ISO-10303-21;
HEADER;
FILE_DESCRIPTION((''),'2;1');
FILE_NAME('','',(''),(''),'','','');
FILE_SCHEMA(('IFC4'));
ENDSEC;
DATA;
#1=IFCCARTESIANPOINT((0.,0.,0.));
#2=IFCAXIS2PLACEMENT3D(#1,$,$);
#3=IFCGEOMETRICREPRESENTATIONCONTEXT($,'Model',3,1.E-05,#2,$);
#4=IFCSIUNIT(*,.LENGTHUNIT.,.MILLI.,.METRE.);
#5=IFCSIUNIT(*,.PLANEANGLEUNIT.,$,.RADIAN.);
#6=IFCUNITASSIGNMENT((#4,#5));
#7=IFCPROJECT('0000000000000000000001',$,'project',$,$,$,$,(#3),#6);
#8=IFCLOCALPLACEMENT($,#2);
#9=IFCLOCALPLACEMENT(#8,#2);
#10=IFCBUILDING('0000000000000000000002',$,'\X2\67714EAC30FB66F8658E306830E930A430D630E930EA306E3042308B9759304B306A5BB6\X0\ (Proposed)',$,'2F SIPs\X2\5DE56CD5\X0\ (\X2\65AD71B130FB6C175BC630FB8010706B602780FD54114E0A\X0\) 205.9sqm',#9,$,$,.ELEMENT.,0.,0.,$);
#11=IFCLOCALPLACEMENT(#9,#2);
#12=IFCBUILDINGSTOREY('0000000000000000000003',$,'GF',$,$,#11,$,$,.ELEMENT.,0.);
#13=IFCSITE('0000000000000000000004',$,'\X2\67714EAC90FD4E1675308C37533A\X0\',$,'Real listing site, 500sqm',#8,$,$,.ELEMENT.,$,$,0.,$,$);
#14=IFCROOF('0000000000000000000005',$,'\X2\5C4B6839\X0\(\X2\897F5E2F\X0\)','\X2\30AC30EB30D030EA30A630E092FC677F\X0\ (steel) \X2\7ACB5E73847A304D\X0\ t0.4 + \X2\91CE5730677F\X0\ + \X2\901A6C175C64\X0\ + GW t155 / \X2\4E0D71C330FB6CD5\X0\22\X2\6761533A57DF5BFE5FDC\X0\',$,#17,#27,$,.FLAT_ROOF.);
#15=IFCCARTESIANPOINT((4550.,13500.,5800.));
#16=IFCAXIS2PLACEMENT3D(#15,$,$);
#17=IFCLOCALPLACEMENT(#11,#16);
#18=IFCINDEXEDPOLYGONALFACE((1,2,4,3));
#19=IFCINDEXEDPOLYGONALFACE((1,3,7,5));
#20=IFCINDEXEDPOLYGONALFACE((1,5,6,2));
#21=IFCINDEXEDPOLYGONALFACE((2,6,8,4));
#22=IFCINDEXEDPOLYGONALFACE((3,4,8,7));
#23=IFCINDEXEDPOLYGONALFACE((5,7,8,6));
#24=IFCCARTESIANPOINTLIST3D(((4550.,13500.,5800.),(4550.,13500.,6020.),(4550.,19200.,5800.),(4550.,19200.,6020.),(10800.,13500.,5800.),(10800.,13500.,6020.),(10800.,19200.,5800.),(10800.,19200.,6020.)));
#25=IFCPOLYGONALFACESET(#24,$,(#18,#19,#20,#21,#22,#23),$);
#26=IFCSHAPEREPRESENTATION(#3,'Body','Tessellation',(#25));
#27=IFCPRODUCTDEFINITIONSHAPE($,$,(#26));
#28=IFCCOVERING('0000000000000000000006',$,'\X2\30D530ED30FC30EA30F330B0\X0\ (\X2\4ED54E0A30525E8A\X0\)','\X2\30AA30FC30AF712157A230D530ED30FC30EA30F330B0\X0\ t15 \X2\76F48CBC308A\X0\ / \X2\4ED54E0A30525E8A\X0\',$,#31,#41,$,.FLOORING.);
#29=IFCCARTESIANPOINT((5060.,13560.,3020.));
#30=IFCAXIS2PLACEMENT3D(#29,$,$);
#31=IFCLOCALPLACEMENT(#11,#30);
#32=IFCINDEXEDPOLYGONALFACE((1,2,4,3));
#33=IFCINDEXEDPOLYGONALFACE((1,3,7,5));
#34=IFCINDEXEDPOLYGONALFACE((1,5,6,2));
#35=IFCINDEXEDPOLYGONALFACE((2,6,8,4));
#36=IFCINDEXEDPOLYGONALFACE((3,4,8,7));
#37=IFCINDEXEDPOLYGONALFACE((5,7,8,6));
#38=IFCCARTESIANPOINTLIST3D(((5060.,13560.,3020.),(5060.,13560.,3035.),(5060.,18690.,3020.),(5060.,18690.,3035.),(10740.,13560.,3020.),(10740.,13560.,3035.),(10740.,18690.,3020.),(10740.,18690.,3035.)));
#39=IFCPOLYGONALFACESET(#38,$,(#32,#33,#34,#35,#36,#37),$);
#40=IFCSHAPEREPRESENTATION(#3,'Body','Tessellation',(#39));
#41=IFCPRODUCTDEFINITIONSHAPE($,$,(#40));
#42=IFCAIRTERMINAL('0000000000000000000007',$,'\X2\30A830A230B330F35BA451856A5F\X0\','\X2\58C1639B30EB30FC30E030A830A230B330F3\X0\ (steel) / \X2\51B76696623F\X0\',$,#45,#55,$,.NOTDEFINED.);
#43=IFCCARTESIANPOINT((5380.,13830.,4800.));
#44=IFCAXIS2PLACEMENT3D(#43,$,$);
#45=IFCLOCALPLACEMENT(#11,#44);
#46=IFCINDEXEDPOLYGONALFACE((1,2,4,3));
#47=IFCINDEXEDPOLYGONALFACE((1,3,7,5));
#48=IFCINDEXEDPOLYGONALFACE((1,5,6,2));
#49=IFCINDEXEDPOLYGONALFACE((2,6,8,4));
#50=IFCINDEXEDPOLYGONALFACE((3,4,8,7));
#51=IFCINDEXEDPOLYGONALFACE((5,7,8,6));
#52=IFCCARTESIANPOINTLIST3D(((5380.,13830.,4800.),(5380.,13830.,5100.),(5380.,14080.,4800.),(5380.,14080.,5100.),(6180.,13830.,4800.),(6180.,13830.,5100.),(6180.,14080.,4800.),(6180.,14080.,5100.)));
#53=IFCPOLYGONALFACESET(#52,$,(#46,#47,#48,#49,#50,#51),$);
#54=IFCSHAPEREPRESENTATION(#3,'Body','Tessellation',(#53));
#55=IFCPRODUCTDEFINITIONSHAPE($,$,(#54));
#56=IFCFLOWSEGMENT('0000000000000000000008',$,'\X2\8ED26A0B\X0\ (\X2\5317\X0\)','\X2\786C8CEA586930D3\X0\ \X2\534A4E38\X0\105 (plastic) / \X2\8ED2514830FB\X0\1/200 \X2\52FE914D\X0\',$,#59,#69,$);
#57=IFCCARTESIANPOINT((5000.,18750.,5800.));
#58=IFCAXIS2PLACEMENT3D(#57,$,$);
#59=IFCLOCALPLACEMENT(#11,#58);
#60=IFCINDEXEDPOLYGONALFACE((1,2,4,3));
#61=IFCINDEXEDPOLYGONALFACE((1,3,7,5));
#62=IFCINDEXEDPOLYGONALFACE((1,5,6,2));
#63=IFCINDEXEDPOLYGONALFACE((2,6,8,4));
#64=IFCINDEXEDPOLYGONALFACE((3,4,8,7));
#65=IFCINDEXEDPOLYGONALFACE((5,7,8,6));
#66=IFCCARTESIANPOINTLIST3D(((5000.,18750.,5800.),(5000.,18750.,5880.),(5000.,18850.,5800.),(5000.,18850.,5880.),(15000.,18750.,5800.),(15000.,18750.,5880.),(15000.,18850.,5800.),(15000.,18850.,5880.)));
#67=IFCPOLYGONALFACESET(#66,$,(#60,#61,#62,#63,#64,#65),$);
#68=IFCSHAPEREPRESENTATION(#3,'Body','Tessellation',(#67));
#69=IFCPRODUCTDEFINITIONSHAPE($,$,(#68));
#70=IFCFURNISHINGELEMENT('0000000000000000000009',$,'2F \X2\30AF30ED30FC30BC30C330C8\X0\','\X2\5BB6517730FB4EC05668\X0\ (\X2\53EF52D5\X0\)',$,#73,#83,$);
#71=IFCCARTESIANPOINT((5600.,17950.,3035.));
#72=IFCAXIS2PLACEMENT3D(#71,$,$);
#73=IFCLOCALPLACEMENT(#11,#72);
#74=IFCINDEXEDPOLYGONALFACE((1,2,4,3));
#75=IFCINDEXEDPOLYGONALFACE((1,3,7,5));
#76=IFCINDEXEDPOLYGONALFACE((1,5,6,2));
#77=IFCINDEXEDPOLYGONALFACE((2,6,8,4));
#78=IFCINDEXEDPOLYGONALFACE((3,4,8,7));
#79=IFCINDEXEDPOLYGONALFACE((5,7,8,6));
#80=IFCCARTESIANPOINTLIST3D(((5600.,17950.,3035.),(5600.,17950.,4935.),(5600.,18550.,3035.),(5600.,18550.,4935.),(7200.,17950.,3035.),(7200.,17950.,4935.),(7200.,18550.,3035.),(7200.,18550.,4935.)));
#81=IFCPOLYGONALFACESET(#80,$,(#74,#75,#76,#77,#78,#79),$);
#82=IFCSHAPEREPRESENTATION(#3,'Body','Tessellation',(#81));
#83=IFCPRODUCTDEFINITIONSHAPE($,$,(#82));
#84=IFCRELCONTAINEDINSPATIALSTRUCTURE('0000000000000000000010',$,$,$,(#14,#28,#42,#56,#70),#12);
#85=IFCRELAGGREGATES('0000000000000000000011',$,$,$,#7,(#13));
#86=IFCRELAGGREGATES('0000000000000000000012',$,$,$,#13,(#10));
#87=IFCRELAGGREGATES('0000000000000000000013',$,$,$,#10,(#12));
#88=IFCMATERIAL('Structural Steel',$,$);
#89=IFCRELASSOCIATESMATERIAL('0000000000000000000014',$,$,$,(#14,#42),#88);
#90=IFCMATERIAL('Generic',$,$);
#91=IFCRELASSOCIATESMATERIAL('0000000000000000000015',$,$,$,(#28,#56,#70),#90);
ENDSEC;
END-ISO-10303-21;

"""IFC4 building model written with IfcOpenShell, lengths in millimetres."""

from ifc_helpers import new_model, si_unit, frame, frame_2d, origin, place, context, project, spatial, rectangle, extrude, material, element, save


model = new_model("IFC4")

# Units and contexts
model_context = context("Model", 3, precision=1e-05, world=origin())
ifc_project = project(units=[si_unit("LENGTHUNIT", "METRE", prefix="MILLI"), si_unit("PLANEANGLEUNIT", "RADIAN")], contexts=[model_context])

# Site, building, storey
site_placement = place(None, origin())
site = spatial("IfcSite", under=ifc_project, at=site_placement, Name="東京都世田谷区", ObjectType="Real listing site, 500sqm", CompositionType="ELEMENT", RefElevation=0.0)
building_placement = place(site_placement, origin())
building = spatial("IfcBuilding", under=site, at=building_placement, Name="東京・書斎とライブラリのある静かな家 (Proposed)", ObjectType="2F SIPs工法 (断熱・気密・耐火性能向上) 205.9sqm", CompositionType="ELEMENT", ElevationOfRefHeight=0.0, ElevationOfTerrain=0.0)
storey_placement = place(building_placement, origin())
storey = spatial("IfcBuildingStorey", under=building, at=storey_placement, Name="GF", CompositionType="ELEMENT", Elevation=0.0)

# Roof
ifc_material_1 = material(Name="Structural Steel")
for number, where, name in (
    (1, (4550.0, 13500.0, 5800.0), "屋根(西帯)"),
):
    element("IfcRoof", number, at=place(storey_placement, frame(where)), inside=storey, material=ifc_material_1, Name=name, Description="ガルバリウム鋼板 (steel) 立平葺き t0.4 + 野地板 + 通気層 + GW t155 / 不燃・法22条区域対応", PredefinedType="FLAT_ROOF", context=model_context, shape_type="SweptSolid", body=[
        extrude(rectangle(XDim=6250.0, YDim=5700.0, at=frame_2d((3125.0, 2850.0))), frame((4550.0, 13500.0, 5800.0)), (0.0, 0.0, 1.0), 220.0),
    ])

# Covering
ifc_material_2 = material(Name="Generic")
covering_placement = place(storey_placement, frame((5060.0, 13560.0, 3020.0)))
element("IfcCovering", 2, at=covering_placement, inside=storey, material=ifc_material_2, Name="フローリング (仕上げ床)", Description="オーク無垢フローリング t15 直貼り / 仕上げ床", PredefinedType="FLOORING", context=model_context, shape_type="SweptSolid", body=[
    extrude(rectangle(XDim=5680.0, YDim=5130.0, at=frame_2d((2840.0, 2565.0))), frame((5060.0, 13560.0, 3020.0)), (0.0, 0.0, 1.0), 15.0),
])

# Air terminal
air_terminal_placement = place(storey_placement, frame((5380.0, 13830.0, 4800.0)))
element("IfcAirTerminal", 3, at=air_terminal_placement, inside=storey, material=ifc_material_1, Name="エアコン室内機", Description="壁掛ルームエアコン (steel) / 冷暖房", PredefinedType="NOTDEFINED", context=model_context, shape_type="SweptSolid", body=[
    extrude(rectangle(XDim=800.0, YDim=250.0, at=frame_2d((400.0, 125.0))), frame((5380.0, 13830.0, 4800.0)), (0.0, 0.0, 1.0), 300.0),
])

# Flow segment
flow_segment_placement = place(storey_placement, frame((5000.0, 18750.0, 5800.0)))
element("IfcFlowSegment", 4, at=flow_segment_placement, inside=storey, material=ifc_material_2, Name="軒樋 (北)", Description="硬質塩ビ 半丸105 (plastic) / 軒先・1/200 勾配", context=model_context, shape_type="SweptSolid", body=[
    extrude(rectangle(XDim=10000.0, YDim=100.0, at=frame_2d((5000.0, 50.0))), frame((5000.0, 18750.0, 5800.0)), (0.0, 0.0, 1.0), 80.0),
])

# Furnishing element
furnishing_placement = place(storey_placement, frame((5600.0, 17950.0, 3035.0)))
element("IfcFurnishingElement", 5, at=furnishing_placement, inside=storey, material=ifc_material_2, Name="2F クローゼット", Description="家具・什器 (可動)", context=model_context, shape_type="SweptSolid", body=[
    extrude(rectangle(XDim=1600.0, YDim=600.0, at=frame_2d((800.0, 300.0))), frame((5600.0, 17950.0, 3035.0)), (0.0, 0.0, 1.0), 1900.0),
])

save(model, "model.ifc")
